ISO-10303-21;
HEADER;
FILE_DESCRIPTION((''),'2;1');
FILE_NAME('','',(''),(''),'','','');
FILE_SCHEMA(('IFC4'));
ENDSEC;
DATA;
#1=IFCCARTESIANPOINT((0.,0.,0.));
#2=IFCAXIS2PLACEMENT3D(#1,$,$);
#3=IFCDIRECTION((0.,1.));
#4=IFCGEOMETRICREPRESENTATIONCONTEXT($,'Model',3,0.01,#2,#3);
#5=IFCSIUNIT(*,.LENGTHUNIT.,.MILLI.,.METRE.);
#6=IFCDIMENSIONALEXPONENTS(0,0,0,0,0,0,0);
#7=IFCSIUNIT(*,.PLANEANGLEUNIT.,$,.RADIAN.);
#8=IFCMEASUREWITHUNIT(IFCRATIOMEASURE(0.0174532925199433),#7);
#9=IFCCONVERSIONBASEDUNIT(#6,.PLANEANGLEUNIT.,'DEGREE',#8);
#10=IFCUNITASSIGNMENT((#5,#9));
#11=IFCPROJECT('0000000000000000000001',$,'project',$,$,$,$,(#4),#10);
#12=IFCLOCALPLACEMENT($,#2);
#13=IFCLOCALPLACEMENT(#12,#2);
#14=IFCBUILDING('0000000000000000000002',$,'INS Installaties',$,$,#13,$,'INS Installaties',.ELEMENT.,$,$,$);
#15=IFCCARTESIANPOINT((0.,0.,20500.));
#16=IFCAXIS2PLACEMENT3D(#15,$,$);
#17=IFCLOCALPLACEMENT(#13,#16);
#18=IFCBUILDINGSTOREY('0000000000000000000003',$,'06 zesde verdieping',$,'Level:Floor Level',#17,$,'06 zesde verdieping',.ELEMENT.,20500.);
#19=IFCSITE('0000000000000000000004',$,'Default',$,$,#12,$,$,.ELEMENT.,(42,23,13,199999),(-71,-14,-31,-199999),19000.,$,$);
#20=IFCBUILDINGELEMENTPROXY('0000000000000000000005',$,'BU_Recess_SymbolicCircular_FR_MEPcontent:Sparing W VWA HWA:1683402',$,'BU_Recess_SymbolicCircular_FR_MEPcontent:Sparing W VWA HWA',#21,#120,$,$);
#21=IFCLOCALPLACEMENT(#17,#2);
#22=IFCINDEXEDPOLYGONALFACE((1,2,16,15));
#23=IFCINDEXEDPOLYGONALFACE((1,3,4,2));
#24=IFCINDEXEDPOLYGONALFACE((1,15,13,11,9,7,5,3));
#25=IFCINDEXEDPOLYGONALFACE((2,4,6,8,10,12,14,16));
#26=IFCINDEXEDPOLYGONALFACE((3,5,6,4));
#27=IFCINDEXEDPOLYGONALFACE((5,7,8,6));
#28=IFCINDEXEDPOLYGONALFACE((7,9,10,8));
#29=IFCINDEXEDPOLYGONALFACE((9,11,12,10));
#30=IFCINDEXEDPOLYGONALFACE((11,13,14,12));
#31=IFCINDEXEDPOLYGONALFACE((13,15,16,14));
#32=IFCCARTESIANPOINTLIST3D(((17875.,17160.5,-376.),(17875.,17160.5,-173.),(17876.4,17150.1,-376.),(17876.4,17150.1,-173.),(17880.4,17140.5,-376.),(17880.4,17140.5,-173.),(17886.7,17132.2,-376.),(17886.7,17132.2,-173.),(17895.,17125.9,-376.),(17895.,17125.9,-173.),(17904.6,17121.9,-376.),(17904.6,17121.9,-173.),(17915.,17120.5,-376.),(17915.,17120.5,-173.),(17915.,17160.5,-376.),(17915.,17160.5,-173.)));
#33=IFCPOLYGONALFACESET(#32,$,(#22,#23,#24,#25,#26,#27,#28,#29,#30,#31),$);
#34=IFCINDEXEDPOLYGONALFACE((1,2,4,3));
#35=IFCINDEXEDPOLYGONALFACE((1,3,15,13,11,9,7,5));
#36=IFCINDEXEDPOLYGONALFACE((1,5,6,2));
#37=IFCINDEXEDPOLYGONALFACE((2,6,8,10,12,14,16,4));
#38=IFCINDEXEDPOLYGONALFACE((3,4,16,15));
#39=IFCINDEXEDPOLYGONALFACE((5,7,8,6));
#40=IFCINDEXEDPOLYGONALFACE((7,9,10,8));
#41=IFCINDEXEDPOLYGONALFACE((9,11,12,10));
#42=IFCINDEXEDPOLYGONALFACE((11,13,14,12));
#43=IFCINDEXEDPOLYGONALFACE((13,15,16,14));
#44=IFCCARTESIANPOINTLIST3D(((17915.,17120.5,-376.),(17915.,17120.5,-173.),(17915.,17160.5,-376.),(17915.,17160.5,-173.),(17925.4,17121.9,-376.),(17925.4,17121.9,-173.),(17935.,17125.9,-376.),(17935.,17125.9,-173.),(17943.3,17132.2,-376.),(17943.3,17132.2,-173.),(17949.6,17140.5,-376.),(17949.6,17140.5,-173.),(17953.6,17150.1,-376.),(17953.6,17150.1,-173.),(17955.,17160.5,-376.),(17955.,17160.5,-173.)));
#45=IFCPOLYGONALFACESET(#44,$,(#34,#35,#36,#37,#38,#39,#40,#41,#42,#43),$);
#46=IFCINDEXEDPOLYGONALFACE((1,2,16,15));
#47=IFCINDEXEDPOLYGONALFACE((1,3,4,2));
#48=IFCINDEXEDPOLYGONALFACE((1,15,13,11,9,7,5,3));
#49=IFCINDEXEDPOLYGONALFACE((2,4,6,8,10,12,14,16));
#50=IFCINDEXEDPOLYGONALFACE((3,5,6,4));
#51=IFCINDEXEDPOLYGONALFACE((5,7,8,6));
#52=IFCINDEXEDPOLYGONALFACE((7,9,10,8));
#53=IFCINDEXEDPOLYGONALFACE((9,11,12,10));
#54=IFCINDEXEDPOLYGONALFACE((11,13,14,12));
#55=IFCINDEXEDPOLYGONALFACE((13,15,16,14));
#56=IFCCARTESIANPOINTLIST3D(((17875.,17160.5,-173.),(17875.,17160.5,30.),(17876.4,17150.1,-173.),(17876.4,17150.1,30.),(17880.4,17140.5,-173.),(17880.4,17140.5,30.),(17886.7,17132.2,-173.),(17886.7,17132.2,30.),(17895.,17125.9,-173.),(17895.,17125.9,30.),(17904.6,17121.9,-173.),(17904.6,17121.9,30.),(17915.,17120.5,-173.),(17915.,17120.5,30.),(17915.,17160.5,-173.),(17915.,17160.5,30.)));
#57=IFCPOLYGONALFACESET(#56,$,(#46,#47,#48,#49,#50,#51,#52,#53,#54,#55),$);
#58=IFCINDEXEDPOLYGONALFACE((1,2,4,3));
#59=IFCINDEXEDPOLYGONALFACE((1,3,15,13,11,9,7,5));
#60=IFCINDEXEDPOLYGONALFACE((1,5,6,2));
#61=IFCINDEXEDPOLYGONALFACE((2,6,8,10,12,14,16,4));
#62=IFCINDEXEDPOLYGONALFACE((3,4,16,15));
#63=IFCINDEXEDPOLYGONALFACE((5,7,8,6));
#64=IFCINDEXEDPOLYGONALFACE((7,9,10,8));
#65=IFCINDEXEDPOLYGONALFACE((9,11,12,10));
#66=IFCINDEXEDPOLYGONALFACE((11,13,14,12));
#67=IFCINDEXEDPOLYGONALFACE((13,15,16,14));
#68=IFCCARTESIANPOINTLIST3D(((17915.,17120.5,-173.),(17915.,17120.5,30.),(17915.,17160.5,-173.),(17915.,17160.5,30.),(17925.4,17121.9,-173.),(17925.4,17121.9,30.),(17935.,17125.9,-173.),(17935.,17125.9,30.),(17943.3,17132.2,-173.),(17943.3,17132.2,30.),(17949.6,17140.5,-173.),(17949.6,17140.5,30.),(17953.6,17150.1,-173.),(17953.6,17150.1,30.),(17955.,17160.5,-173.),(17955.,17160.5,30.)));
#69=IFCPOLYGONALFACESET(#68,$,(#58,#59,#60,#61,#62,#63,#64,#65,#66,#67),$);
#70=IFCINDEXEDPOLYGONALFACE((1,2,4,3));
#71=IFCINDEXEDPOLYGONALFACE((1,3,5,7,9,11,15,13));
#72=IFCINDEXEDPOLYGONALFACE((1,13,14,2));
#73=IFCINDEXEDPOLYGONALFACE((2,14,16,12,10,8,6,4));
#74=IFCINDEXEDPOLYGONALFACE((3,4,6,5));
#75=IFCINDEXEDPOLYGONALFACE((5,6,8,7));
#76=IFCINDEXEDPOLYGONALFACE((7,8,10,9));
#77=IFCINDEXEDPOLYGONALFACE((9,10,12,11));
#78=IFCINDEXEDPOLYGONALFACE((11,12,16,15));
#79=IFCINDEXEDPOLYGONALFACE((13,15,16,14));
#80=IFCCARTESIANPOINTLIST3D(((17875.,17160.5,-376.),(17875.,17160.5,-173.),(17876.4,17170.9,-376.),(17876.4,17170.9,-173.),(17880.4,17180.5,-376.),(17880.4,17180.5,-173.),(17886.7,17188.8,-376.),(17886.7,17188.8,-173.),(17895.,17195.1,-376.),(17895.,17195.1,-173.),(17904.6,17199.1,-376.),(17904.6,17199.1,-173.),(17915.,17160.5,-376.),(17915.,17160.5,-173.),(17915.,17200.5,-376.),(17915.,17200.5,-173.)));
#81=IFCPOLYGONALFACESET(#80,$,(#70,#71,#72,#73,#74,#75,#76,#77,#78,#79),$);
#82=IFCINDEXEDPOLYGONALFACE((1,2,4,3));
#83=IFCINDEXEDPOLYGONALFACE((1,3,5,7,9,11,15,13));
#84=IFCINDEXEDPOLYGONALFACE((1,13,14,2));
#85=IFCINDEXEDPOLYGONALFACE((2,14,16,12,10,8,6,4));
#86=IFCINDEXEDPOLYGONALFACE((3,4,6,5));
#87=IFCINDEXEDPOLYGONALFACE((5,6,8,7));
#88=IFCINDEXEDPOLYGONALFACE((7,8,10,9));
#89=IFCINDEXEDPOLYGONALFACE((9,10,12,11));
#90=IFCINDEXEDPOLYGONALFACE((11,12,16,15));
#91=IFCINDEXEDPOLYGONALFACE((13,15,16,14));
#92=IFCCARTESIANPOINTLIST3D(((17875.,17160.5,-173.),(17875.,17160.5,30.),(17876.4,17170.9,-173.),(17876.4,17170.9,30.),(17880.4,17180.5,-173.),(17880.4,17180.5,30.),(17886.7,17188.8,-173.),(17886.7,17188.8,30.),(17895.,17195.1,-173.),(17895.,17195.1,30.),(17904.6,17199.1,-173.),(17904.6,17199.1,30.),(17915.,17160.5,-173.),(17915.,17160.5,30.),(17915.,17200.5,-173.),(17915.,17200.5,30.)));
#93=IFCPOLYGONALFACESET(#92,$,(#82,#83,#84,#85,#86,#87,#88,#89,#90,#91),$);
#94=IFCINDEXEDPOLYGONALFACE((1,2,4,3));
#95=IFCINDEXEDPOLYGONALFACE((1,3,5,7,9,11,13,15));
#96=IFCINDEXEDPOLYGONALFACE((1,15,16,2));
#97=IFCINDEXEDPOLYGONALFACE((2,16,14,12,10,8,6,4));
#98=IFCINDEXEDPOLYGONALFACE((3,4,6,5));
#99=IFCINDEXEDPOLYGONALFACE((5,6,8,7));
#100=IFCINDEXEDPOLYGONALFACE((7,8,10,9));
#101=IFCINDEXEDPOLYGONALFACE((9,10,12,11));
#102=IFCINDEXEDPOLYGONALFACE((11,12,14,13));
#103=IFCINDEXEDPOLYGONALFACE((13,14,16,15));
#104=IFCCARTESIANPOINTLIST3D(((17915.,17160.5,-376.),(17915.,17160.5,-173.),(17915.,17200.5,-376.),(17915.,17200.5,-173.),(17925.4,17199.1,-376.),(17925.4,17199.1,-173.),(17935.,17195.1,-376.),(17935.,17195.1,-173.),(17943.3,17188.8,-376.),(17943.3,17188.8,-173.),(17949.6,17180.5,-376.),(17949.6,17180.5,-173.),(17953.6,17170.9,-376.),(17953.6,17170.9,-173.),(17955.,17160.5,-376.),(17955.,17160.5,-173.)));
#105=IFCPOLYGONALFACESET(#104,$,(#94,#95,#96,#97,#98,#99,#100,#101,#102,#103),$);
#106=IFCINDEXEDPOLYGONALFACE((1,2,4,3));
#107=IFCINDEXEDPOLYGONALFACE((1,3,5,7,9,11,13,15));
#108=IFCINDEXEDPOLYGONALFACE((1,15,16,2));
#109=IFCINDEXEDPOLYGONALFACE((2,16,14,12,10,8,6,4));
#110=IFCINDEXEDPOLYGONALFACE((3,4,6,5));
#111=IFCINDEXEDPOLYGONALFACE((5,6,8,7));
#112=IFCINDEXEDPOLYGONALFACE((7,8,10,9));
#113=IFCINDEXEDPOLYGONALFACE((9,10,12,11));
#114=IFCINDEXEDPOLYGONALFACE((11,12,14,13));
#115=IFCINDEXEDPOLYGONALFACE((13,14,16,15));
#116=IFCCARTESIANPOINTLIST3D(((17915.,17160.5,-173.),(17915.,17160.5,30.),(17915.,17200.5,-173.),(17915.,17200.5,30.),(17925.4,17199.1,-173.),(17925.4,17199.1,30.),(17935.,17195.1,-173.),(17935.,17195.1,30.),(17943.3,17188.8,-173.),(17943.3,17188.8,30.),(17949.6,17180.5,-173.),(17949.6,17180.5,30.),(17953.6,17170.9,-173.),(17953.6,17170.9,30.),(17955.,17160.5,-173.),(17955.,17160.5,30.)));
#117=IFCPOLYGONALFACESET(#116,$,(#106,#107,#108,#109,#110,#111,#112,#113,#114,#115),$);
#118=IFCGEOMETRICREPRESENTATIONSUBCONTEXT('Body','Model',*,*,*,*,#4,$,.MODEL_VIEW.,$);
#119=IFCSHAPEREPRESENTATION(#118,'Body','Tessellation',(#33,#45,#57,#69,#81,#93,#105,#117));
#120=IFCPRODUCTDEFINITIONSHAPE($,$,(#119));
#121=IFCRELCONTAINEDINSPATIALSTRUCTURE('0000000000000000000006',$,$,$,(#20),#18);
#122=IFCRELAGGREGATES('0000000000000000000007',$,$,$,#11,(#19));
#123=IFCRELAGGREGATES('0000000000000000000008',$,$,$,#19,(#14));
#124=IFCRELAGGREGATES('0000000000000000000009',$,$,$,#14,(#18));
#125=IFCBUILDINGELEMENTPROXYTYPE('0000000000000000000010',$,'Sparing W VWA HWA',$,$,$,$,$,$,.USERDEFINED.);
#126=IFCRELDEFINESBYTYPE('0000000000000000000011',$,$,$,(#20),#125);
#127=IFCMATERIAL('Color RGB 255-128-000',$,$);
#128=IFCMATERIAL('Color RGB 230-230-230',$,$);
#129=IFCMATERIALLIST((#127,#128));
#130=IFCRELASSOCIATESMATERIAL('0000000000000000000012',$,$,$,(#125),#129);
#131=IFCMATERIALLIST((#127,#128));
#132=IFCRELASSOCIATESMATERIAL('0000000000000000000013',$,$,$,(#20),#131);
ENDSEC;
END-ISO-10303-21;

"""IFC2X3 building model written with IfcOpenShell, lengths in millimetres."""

from ifc_helpers import new_model, entity, si_unit, converted_unit, direction, frame, frame_2d, origin, place, context, subcontext, project, spatial, polyline, circle_curve, parameter, trimmed, segment, composite_curve, outline, extrude, source, transform, mapped, material, material_list, type_object, type_shapes, element, save


model = new_model("IFC2X3")

# Units and contexts
model_context = context("Model", 3, precision=0.01, world=origin(), true_north=direction((0.0, 1.0)))
body_context = subcontext(model_context, "Body", "Model", "MODEL_VIEW")
ifc_project = project(units=[si_unit("LENGTHUNIT", "METRE", prefix="MILLI"), converted_unit("PLANEANGLEUNIT", "DEGREE", entity("IfcRatioMeasure", 0.0174532925199433), si_unit("PLANEANGLEUNIT", "RADIAN"), dimensions=[0, 0, 0, 0, 0, 0, 0])], contexts=[model_context])

# Site, building, storey
site_placement = place(None, origin())
site = spatial("IfcSite", under=ifc_project, at=site_placement, Name="Default", CompositionType="ELEMENT", RefLatitude=(42, 23, 13, 199999), RefLongitude=(-71, -14, -31, -199999), RefElevation=19000.0)
building_placement = place(site_placement, origin())
building = spatial("IfcBuilding", under=site, at=building_placement, Name="INS Installaties", LongName="INS Installaties", CompositionType="ELEMENT")
storey_placement = place(building_placement, frame((0.0, 0.0, 20500.0)))
storey = spatial("IfcBuildingStorey", under=building, at=storey_placement, Name="06 zesde verdieping", ObjectType="Level:Floor Level", LongName="06 zesde verdieping", CompositionType="ELEMENT", Elevation=20500.0)

# Building element proxy
ifc_material_1 = material(Name="Color RGB 255-128-000")
ifc_material_2 = material(Name="Color RGB 230-230-230")
ifc_material_list_1 = material_list([ifc_material_1, ifc_material_2])
building_element_proxy_type_1 = type_object("IfcBuildingElementProxyType", Name="Sparing W VWA HWA", PredefinedType="USERDEFINED", material=ifc_material_list_1)
shared_shape_1 = source(origin(), body_context, "Body", "SweptSolid", [
    extrude(outline(composite_curve([segment(trimmed(circle_curve(frame_2d((13.3, 13.3), x_axis=(1.0, 0.0)), 40.0), [parameter(180.0)], [parameter(270.0)], True, "PARAMETER"), True, "CONTINUOUS"), segment(polyline([(13.3, -26.7), (13.3, 13.3)]), True, "CONTINUOUS"), segment(polyline([(13.3, 13.3), (-26.7, 13.3)]), True, "CONTINUOUS")], self_intersect=False)), frame((13.3, 13.3, -403.0), z_axis=(0.0, 0.0, 1.0), x_axis=(-1.0, 0.0, 0.0)), (0.0, 0.0, 1.0), 203.0),
    extrude(outline(composite_curve([segment(polyline([(-26.7, -13.3), (13.3, -13.3)]), True, "CONTINUOUS"), segment(polyline([(13.3, -13.3), (13.3, 26.7)]), True, "CONTINUOUS"), segment(trimmed(circle_curve(frame_2d((13.3, -13.3), x_axis=(1.0, 0.0)), 40.0), [parameter(90.0)], [parameter(180.0)], True, "PARAMETER"), True, "CONTINUOUS")], self_intersect=False)), frame((-13.3, 13.3, -403.0)), (0.0, 0.0, 1.0), 203.0),
    extrude(outline(composite_curve([segment(trimmed(circle_curve(frame_2d((13.3, 13.3), x_axis=(1.0, 0.0)), 40.0), [parameter(180.0)], [parameter(270.0)], True, "PARAMETER"), True, "CONTINUOUS"), segment(polyline([(13.3, -26.7), (13.3, 13.3)]), True, "CONTINUOUS"), segment(polyline([(13.3, 13.3), (-26.7, 13.3)]), True, "CONTINUOUS")], self_intersect=False)), frame((13.3, 13.3, -200.0), z_axis=(0.0, 0.0, 1.0), x_axis=(-1.0, 0.0, 0.0)), (0.0, 0.0, 1.0), 203.0),
    extrude(outline(composite_curve([segment(polyline([(-26.7, -13.3), (13.3, -13.3)]), True, "CONTINUOUS"), segment(polyline([(13.3, -13.3), (13.3, 26.7)]), True, "CONTINUOUS"), segment(trimmed(circle_curve(frame_2d((13.3, -13.3), x_axis=(1.0, 0.0)), 40.0), [parameter(90.0)], [parameter(180.0)], True, "PARAMETER"), True, "CONTINUOUS")], self_intersect=False)), frame((-13.3, 13.3, -200.0)), (0.0, 0.0, 1.0), 203.0),
    extrude(outline(composite_curve([segment(polyline([(-26.7, -13.3), (13.3, -13.3)]), True, "CONTINUOUS"), segment(polyline([(13.3, -13.3), (13.3, 26.7)]), True, "CONTINUOUS"), segment(trimmed(circle_curve(frame_2d((13.3, -13.3), x_axis=(1.0, 0.0)), 40.0), [parameter(90.0)], [parameter(180.0)], True, "PARAMETER"), True, "CONTINUOUS")], self_intersect=False)), frame((13.3, -13.3, -403.0), z_axis=(0.0, 0.0, 1.0), x_axis=(-1.0, 0.0, 0.0)), (0.0, 0.0, 1.0), 203.0),
    extrude(outline(composite_curve([segment(polyline([(-26.7, -13.3), (13.3, -13.3)]), True, "CONTINUOUS"), segment(polyline([(13.3, -13.3), (13.3, 26.7)]), True, "CONTINUOUS"), segment(trimmed(circle_curve(frame_2d((13.3, -13.3), x_axis=(1.0, 0.0)), 40.0), [parameter(90.0)], [parameter(180.0)], True, "PARAMETER"), True, "CONTINUOUS")], self_intersect=False)), frame((13.3, -13.3, -200.0), z_axis=(0.0, 0.0, 1.0), x_axis=(-1.0, 0.0, 0.0)), (0.0, 0.0, 1.0), 203.0),
    extrude(outline(composite_curve([segment(trimmed(circle_curve(frame_2d((13.3, 13.3), x_axis=(1.0, 0.0)), 40.0), [parameter(180.0)], [parameter(270.0)], True, "PARAMETER"), True, "CONTINUOUS"), segment(polyline([(13.3, -26.7), (13.3, 13.3)]), True, "CONTINUOUS"), segment(polyline([(13.3, 13.3), (-26.7, 13.3)]), True, "CONTINUOUS")], self_intersect=False)), frame((-13.3, -13.3, -403.0)), (0.0, 0.0, 1.0), 203.0),
    extrude(outline(composite_curve([segment(trimmed(circle_curve(frame_2d((13.3, 13.3), x_axis=(1.0, 0.0)), 40.0), [parameter(180.0)], [parameter(270.0)], True, "PARAMETER"), True, "CONTINUOUS"), segment(polyline([(13.3, -26.7), (13.3, 13.3)]), True, "CONTINUOUS"), segment(polyline([(13.3, 13.3), (-26.7, 13.3)]), True, "CONTINUOUS")], self_intersect=False)), frame((-13.3, -13.3, -200.0)), (0.0, 0.0, 1.0), 203.0),
])
type_shapes(building_element_proxy_type_1, [shared_shape_1])
ifc_material_list_2 = material_list([ifc_material_1, ifc_material_2])
proxy_1_placement = place(storey_placement, frame((17915.0, 17160.5, 27.0), z_axis=(0.0, 0.0, 1.0), x_axis=(-1.0, 0.0, 0.0)))
element("IfcBuildingElementProxy", 1, at=proxy_1_placement, inside=storey, type_object=building_element_proxy_type_1, material=ifc_material_list_2, Name="BU_Recess_SymbolicCircular_FR_MEPcontent:Sparing W VWA HWA:1683402", ObjectType="BU_Recess_SymbolicCircular_FR_MEPcontent:Sparing W VWA HWA", context=body_context, shape_type="MappedRepresentation", body=[
    mapped(shared_shape_1, transform((0.0, 0.0, 0.0), scale=1.0)),
])

save(model, "model.ifc")
